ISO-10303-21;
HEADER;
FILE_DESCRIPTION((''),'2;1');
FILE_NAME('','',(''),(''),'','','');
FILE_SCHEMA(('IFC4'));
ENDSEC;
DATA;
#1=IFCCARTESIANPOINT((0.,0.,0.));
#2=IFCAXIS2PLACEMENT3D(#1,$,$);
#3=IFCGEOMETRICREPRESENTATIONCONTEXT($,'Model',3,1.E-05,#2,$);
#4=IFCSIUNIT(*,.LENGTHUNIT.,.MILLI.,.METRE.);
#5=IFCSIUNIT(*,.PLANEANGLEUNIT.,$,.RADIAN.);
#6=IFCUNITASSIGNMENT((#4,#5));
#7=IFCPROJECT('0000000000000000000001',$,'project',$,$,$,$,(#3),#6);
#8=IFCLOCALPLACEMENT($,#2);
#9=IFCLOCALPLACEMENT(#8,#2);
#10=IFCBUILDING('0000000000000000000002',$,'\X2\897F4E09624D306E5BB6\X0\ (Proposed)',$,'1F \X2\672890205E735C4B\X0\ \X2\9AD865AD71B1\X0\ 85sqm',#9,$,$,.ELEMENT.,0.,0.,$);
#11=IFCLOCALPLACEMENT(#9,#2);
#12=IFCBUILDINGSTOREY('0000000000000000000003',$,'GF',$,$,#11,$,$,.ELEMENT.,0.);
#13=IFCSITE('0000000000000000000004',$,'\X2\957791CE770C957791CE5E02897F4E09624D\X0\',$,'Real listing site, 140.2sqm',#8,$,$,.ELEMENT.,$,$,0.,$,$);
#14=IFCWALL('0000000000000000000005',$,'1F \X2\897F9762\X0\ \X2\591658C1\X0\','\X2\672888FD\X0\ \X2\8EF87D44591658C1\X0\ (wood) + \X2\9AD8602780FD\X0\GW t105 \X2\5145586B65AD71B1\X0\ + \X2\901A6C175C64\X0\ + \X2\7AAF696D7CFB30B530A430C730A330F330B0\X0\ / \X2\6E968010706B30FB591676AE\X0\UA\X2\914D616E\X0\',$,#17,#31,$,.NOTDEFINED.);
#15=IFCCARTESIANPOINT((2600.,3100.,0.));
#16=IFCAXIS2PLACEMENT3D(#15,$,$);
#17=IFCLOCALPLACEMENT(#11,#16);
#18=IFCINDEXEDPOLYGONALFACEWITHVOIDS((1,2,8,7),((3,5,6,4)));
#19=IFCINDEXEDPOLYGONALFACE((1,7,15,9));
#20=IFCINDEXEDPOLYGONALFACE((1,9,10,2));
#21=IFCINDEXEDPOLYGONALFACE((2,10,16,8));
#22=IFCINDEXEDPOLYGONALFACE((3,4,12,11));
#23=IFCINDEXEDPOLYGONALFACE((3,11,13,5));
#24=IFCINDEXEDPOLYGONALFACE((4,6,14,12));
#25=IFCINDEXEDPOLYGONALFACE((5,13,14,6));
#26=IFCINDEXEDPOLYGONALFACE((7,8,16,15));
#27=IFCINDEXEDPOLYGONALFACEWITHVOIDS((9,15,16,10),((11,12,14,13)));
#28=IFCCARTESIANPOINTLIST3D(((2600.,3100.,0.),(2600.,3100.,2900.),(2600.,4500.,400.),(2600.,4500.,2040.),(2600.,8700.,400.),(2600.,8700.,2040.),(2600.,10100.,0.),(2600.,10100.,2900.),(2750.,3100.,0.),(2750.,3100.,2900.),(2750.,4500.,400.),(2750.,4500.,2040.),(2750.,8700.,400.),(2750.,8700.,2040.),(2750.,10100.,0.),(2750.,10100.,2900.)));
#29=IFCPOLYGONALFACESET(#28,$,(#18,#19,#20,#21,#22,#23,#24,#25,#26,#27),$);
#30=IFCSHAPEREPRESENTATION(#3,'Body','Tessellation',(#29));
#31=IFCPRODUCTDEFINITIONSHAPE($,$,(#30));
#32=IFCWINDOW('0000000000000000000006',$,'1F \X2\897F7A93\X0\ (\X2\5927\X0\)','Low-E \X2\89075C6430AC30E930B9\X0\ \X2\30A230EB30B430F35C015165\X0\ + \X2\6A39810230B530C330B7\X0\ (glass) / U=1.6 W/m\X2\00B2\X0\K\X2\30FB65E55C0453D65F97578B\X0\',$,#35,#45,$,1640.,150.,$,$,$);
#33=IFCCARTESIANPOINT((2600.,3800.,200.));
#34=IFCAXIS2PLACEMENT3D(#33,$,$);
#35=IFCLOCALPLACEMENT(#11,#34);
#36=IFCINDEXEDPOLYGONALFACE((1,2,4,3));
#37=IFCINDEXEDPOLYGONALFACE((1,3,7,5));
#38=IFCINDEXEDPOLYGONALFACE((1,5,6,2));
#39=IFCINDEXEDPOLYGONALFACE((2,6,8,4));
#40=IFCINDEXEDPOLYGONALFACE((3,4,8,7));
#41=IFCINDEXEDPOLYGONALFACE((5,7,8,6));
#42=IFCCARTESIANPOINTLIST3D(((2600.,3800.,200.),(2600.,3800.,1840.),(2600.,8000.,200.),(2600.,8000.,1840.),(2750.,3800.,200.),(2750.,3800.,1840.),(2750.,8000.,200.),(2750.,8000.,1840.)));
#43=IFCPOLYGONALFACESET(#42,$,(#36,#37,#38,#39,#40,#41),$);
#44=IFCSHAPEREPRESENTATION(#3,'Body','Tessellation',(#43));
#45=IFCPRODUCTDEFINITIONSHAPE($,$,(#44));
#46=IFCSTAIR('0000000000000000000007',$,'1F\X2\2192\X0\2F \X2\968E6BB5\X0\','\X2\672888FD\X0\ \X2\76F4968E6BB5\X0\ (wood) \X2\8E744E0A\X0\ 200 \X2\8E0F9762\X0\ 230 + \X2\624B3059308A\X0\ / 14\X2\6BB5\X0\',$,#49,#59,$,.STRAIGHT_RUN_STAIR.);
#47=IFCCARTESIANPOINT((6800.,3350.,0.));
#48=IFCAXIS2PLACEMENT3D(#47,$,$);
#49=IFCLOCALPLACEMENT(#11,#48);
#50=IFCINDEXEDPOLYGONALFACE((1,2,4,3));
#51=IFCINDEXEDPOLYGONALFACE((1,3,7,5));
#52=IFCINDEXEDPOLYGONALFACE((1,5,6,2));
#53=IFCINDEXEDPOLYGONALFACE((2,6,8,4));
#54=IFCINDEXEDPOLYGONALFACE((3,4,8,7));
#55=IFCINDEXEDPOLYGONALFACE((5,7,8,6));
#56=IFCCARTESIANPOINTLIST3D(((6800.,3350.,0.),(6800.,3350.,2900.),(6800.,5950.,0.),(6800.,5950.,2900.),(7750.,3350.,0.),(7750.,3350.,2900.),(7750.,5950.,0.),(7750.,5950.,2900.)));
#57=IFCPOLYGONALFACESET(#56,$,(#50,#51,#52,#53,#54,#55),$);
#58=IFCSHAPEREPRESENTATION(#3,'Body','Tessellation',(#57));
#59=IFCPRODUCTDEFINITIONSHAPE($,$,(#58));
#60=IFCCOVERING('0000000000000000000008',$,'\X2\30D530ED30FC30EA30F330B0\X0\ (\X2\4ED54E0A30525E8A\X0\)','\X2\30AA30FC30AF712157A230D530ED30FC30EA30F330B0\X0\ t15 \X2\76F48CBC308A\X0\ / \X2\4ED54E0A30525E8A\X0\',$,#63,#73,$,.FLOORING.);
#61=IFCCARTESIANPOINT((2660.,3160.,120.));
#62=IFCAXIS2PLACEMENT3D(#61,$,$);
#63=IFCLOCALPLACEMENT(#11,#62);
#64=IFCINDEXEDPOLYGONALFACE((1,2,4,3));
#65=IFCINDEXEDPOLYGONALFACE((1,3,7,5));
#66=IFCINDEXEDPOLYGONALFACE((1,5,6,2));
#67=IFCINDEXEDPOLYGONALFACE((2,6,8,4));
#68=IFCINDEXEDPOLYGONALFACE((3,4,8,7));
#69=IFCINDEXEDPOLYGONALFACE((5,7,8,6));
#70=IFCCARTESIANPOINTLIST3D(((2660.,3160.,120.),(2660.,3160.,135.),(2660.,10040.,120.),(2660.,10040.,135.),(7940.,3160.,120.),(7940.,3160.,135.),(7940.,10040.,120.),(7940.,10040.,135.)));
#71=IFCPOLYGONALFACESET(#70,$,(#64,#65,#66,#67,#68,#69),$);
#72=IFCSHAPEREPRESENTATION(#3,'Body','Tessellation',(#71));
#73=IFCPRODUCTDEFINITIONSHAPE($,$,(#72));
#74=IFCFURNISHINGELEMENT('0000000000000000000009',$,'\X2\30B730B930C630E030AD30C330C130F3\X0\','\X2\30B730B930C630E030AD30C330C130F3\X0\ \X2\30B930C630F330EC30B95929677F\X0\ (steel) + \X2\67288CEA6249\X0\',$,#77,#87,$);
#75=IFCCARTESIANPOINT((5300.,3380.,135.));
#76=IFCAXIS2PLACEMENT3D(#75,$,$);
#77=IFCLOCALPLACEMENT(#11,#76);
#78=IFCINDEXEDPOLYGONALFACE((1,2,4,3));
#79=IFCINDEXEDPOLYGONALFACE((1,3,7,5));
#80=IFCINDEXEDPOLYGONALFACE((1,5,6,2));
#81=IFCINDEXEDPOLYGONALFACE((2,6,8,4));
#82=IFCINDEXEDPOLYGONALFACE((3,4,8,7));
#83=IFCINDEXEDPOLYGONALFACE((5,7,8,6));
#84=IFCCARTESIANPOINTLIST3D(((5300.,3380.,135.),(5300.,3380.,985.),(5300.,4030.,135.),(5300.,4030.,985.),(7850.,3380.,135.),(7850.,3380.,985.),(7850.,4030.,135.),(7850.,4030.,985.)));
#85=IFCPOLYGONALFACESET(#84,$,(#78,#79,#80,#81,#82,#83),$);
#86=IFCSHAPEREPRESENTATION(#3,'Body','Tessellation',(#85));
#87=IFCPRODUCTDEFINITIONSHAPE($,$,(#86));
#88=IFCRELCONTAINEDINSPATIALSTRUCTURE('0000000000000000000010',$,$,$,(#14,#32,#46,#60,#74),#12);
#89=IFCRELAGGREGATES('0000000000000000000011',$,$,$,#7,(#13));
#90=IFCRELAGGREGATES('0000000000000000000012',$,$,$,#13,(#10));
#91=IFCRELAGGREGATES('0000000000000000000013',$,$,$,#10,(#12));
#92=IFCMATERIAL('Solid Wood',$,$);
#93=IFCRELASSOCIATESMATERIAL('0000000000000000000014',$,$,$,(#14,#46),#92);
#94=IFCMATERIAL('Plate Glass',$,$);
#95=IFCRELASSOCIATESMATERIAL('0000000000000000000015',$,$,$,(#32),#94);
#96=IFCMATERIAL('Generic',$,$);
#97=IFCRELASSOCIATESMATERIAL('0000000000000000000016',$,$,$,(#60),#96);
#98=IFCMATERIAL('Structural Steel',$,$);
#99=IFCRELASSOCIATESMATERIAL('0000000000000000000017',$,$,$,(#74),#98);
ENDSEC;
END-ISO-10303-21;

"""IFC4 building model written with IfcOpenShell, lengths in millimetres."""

from ifc_helpers import new_model, si_unit, frame, frame_2d, origin, place, context, project, spatial, rectangle, extrude, material, element, fill, save


model = new_model("IFC4")

# Units and contexts
model_context = context("Model", 3, precision=1e-05, world=origin())
ifc_project = project(units=[si_unit("LENGTHUNIT", "METRE", prefix="MILLI"), si_unit("PLANEANGLEUNIT", "RADIAN")], contexts=[model_context])

# Site, building, storey
site_placement = place(None, origin())
site = spatial("IfcSite", under=ifc_project, at=site_placement, Name="長野県長野市西三才", ObjectType="Real listing site, 140.2sqm", CompositionType="ELEMENT", RefElevation=0.0)
building_placement = place(site_placement, origin())
building = spatial("IfcBuilding", under=site, at=building_placement, Name="西三才の家 (Proposed)", ObjectType="1F 木造平屋 高断熱 85sqm", CompositionType="ELEMENT", ElevationOfRefHeight=0.0, ElevationOfTerrain=0.0)
storey_placement = place(building_placement, origin())
storey = spatial("IfcBuildingStorey", under=building, at=storey_placement, Name="GF", CompositionType="ELEMENT", Elevation=0.0)

# Shared definitions
ifc_material_1 = material(Name="Solid Wood")
ifc_material_2 = material(Name="Generic")

# Shared definitions
ifc_material_3 = material(Name="Plate Glass")

# Wall, opening, window
wall_1_placement = place(storey_placement, frame((2600.0, 3100.0, 0.0)))
wall_1 = element("IfcWall", 1, at=wall_1_placement, inside=storey, material=ifc_material_1, Name="1F 西面 外壁", Description="木製 軸組外壁 (wood) + 高性能GW t105 充填断熱 + 通気層 + 窯業系サイディング / 準耐火・外皮UA配慮", PredefinedType="NOTDEFINED", context=model_context, shape_type="SweptSolid", body=[
    extrude(rectangle(XDim=150.0, YDim=7000.0, at=frame_2d((75.0, 3500.0))), frame((2600.0, 3100.0, 0.0)), (0.0, 0.0, 1.0), 2900.0),
])
opening_1_placement = place(storey_placement, frame((2600.0, 3800.0, 200.0)))
opening_1 = element("IfcOpeningElement", 2, at=opening_1_placement, cuts=wall_1, PredefinedType="NOTDEFINED", context=model_context, shape_type="SweptSolid", body=[
    extrude(rectangle(XDim=150.0, YDim=4200.0, at=frame_2d((75.0, 2100.0))), frame((2600.0, 3800.0, 200.0)), (0.0, 0.0, 1.0), 1640.0),
])
window_1_placement = place(storey_placement, frame((2600.0, 3800.0, 200.0)))
window_1 = element("IfcWindow", 3, at=window_1_placement, inside=storey, material=ifc_material_3, Name="1F 西窓 (大)", Description="Low-E 複層ガラス アルゴン封入 + 樹脂サッシ (glass) / U=1.6 W/m²K・日射取得型", OverallHeight=1640.0, OverallWidth=150.0, context=model_context, shape_type="SweptSolid", body=[
    extrude(rectangle(XDim=150.0, YDim=4200.0, at=frame_2d((75.0, 2100.0))), frame((2600.0, 3800.0, 200.0)), (0.0, 0.0, 1.0), 1640.0),
])
fill(opening_1, window_1)

# Stair
stair_placement = place(storey_placement, frame((6800.0, 3350.0, 0.0)))
element("IfcStair", 4, at=stair_placement, inside=storey, material=ifc_material_1, Name="1F→2F 階段", Description="木製 直階段 (wood) 蹴上 200 踏面 230 + 手すり / 14段", PredefinedType="STRAIGHT_RUN_STAIR", context=model_context, shape_type="SweptSolid", body=[
    extrude(rectangle(XDim=950.0, YDim=2600.0, at=frame_2d((475.0, 1300.0))), frame((6800.0, 3350.0, 0.0)), (0.0, 0.0, 1.0), 2900.0),
])

# Covering
covering_placement = place(storey_placement, frame((2660.0, 3160.0, 120.0)))
element("IfcCovering", 5, at=covering_placement, inside=storey, material=ifc_material_2, Name="フローリング (仕上げ床)", Description="オーク無垢フローリング t15 直貼り / 仕上げ床", PredefinedType="FLOORING", context=model_context, shape_type="SweptSolid", body=[
    extrude(rectangle(XDim=5280.0, YDim=6880.0, at=frame_2d((2640.0, 3440.0))), frame((2660.0, 3160.0, 120.0)), (0.0, 0.0, 1.0), 15.0),
])

# Furnishing element
ifc_material_4 = material(Name="Structural Steel")
furnishing_placement = place(storey_placement, frame((5300.0, 3380.0, 135.0)))
element("IfcFurnishingElement", 6, at=furnishing_placement, inside=storey, material=ifc_material_4, Name="システムキッチン", Description="システムキッチン ステンレス天板 (steel) + 木質扉", context=model_context, shape_type="SweptSolid", body=[
    extrude(rectangle(XDim=2550.0, YDim=650.0, at=frame_2d((1275.0, 325.0))), frame((5300.0, 3380.0, 135.0)), (0.0, 0.0, 1.0), 850.0),
])

save(model, "model.ifc")
